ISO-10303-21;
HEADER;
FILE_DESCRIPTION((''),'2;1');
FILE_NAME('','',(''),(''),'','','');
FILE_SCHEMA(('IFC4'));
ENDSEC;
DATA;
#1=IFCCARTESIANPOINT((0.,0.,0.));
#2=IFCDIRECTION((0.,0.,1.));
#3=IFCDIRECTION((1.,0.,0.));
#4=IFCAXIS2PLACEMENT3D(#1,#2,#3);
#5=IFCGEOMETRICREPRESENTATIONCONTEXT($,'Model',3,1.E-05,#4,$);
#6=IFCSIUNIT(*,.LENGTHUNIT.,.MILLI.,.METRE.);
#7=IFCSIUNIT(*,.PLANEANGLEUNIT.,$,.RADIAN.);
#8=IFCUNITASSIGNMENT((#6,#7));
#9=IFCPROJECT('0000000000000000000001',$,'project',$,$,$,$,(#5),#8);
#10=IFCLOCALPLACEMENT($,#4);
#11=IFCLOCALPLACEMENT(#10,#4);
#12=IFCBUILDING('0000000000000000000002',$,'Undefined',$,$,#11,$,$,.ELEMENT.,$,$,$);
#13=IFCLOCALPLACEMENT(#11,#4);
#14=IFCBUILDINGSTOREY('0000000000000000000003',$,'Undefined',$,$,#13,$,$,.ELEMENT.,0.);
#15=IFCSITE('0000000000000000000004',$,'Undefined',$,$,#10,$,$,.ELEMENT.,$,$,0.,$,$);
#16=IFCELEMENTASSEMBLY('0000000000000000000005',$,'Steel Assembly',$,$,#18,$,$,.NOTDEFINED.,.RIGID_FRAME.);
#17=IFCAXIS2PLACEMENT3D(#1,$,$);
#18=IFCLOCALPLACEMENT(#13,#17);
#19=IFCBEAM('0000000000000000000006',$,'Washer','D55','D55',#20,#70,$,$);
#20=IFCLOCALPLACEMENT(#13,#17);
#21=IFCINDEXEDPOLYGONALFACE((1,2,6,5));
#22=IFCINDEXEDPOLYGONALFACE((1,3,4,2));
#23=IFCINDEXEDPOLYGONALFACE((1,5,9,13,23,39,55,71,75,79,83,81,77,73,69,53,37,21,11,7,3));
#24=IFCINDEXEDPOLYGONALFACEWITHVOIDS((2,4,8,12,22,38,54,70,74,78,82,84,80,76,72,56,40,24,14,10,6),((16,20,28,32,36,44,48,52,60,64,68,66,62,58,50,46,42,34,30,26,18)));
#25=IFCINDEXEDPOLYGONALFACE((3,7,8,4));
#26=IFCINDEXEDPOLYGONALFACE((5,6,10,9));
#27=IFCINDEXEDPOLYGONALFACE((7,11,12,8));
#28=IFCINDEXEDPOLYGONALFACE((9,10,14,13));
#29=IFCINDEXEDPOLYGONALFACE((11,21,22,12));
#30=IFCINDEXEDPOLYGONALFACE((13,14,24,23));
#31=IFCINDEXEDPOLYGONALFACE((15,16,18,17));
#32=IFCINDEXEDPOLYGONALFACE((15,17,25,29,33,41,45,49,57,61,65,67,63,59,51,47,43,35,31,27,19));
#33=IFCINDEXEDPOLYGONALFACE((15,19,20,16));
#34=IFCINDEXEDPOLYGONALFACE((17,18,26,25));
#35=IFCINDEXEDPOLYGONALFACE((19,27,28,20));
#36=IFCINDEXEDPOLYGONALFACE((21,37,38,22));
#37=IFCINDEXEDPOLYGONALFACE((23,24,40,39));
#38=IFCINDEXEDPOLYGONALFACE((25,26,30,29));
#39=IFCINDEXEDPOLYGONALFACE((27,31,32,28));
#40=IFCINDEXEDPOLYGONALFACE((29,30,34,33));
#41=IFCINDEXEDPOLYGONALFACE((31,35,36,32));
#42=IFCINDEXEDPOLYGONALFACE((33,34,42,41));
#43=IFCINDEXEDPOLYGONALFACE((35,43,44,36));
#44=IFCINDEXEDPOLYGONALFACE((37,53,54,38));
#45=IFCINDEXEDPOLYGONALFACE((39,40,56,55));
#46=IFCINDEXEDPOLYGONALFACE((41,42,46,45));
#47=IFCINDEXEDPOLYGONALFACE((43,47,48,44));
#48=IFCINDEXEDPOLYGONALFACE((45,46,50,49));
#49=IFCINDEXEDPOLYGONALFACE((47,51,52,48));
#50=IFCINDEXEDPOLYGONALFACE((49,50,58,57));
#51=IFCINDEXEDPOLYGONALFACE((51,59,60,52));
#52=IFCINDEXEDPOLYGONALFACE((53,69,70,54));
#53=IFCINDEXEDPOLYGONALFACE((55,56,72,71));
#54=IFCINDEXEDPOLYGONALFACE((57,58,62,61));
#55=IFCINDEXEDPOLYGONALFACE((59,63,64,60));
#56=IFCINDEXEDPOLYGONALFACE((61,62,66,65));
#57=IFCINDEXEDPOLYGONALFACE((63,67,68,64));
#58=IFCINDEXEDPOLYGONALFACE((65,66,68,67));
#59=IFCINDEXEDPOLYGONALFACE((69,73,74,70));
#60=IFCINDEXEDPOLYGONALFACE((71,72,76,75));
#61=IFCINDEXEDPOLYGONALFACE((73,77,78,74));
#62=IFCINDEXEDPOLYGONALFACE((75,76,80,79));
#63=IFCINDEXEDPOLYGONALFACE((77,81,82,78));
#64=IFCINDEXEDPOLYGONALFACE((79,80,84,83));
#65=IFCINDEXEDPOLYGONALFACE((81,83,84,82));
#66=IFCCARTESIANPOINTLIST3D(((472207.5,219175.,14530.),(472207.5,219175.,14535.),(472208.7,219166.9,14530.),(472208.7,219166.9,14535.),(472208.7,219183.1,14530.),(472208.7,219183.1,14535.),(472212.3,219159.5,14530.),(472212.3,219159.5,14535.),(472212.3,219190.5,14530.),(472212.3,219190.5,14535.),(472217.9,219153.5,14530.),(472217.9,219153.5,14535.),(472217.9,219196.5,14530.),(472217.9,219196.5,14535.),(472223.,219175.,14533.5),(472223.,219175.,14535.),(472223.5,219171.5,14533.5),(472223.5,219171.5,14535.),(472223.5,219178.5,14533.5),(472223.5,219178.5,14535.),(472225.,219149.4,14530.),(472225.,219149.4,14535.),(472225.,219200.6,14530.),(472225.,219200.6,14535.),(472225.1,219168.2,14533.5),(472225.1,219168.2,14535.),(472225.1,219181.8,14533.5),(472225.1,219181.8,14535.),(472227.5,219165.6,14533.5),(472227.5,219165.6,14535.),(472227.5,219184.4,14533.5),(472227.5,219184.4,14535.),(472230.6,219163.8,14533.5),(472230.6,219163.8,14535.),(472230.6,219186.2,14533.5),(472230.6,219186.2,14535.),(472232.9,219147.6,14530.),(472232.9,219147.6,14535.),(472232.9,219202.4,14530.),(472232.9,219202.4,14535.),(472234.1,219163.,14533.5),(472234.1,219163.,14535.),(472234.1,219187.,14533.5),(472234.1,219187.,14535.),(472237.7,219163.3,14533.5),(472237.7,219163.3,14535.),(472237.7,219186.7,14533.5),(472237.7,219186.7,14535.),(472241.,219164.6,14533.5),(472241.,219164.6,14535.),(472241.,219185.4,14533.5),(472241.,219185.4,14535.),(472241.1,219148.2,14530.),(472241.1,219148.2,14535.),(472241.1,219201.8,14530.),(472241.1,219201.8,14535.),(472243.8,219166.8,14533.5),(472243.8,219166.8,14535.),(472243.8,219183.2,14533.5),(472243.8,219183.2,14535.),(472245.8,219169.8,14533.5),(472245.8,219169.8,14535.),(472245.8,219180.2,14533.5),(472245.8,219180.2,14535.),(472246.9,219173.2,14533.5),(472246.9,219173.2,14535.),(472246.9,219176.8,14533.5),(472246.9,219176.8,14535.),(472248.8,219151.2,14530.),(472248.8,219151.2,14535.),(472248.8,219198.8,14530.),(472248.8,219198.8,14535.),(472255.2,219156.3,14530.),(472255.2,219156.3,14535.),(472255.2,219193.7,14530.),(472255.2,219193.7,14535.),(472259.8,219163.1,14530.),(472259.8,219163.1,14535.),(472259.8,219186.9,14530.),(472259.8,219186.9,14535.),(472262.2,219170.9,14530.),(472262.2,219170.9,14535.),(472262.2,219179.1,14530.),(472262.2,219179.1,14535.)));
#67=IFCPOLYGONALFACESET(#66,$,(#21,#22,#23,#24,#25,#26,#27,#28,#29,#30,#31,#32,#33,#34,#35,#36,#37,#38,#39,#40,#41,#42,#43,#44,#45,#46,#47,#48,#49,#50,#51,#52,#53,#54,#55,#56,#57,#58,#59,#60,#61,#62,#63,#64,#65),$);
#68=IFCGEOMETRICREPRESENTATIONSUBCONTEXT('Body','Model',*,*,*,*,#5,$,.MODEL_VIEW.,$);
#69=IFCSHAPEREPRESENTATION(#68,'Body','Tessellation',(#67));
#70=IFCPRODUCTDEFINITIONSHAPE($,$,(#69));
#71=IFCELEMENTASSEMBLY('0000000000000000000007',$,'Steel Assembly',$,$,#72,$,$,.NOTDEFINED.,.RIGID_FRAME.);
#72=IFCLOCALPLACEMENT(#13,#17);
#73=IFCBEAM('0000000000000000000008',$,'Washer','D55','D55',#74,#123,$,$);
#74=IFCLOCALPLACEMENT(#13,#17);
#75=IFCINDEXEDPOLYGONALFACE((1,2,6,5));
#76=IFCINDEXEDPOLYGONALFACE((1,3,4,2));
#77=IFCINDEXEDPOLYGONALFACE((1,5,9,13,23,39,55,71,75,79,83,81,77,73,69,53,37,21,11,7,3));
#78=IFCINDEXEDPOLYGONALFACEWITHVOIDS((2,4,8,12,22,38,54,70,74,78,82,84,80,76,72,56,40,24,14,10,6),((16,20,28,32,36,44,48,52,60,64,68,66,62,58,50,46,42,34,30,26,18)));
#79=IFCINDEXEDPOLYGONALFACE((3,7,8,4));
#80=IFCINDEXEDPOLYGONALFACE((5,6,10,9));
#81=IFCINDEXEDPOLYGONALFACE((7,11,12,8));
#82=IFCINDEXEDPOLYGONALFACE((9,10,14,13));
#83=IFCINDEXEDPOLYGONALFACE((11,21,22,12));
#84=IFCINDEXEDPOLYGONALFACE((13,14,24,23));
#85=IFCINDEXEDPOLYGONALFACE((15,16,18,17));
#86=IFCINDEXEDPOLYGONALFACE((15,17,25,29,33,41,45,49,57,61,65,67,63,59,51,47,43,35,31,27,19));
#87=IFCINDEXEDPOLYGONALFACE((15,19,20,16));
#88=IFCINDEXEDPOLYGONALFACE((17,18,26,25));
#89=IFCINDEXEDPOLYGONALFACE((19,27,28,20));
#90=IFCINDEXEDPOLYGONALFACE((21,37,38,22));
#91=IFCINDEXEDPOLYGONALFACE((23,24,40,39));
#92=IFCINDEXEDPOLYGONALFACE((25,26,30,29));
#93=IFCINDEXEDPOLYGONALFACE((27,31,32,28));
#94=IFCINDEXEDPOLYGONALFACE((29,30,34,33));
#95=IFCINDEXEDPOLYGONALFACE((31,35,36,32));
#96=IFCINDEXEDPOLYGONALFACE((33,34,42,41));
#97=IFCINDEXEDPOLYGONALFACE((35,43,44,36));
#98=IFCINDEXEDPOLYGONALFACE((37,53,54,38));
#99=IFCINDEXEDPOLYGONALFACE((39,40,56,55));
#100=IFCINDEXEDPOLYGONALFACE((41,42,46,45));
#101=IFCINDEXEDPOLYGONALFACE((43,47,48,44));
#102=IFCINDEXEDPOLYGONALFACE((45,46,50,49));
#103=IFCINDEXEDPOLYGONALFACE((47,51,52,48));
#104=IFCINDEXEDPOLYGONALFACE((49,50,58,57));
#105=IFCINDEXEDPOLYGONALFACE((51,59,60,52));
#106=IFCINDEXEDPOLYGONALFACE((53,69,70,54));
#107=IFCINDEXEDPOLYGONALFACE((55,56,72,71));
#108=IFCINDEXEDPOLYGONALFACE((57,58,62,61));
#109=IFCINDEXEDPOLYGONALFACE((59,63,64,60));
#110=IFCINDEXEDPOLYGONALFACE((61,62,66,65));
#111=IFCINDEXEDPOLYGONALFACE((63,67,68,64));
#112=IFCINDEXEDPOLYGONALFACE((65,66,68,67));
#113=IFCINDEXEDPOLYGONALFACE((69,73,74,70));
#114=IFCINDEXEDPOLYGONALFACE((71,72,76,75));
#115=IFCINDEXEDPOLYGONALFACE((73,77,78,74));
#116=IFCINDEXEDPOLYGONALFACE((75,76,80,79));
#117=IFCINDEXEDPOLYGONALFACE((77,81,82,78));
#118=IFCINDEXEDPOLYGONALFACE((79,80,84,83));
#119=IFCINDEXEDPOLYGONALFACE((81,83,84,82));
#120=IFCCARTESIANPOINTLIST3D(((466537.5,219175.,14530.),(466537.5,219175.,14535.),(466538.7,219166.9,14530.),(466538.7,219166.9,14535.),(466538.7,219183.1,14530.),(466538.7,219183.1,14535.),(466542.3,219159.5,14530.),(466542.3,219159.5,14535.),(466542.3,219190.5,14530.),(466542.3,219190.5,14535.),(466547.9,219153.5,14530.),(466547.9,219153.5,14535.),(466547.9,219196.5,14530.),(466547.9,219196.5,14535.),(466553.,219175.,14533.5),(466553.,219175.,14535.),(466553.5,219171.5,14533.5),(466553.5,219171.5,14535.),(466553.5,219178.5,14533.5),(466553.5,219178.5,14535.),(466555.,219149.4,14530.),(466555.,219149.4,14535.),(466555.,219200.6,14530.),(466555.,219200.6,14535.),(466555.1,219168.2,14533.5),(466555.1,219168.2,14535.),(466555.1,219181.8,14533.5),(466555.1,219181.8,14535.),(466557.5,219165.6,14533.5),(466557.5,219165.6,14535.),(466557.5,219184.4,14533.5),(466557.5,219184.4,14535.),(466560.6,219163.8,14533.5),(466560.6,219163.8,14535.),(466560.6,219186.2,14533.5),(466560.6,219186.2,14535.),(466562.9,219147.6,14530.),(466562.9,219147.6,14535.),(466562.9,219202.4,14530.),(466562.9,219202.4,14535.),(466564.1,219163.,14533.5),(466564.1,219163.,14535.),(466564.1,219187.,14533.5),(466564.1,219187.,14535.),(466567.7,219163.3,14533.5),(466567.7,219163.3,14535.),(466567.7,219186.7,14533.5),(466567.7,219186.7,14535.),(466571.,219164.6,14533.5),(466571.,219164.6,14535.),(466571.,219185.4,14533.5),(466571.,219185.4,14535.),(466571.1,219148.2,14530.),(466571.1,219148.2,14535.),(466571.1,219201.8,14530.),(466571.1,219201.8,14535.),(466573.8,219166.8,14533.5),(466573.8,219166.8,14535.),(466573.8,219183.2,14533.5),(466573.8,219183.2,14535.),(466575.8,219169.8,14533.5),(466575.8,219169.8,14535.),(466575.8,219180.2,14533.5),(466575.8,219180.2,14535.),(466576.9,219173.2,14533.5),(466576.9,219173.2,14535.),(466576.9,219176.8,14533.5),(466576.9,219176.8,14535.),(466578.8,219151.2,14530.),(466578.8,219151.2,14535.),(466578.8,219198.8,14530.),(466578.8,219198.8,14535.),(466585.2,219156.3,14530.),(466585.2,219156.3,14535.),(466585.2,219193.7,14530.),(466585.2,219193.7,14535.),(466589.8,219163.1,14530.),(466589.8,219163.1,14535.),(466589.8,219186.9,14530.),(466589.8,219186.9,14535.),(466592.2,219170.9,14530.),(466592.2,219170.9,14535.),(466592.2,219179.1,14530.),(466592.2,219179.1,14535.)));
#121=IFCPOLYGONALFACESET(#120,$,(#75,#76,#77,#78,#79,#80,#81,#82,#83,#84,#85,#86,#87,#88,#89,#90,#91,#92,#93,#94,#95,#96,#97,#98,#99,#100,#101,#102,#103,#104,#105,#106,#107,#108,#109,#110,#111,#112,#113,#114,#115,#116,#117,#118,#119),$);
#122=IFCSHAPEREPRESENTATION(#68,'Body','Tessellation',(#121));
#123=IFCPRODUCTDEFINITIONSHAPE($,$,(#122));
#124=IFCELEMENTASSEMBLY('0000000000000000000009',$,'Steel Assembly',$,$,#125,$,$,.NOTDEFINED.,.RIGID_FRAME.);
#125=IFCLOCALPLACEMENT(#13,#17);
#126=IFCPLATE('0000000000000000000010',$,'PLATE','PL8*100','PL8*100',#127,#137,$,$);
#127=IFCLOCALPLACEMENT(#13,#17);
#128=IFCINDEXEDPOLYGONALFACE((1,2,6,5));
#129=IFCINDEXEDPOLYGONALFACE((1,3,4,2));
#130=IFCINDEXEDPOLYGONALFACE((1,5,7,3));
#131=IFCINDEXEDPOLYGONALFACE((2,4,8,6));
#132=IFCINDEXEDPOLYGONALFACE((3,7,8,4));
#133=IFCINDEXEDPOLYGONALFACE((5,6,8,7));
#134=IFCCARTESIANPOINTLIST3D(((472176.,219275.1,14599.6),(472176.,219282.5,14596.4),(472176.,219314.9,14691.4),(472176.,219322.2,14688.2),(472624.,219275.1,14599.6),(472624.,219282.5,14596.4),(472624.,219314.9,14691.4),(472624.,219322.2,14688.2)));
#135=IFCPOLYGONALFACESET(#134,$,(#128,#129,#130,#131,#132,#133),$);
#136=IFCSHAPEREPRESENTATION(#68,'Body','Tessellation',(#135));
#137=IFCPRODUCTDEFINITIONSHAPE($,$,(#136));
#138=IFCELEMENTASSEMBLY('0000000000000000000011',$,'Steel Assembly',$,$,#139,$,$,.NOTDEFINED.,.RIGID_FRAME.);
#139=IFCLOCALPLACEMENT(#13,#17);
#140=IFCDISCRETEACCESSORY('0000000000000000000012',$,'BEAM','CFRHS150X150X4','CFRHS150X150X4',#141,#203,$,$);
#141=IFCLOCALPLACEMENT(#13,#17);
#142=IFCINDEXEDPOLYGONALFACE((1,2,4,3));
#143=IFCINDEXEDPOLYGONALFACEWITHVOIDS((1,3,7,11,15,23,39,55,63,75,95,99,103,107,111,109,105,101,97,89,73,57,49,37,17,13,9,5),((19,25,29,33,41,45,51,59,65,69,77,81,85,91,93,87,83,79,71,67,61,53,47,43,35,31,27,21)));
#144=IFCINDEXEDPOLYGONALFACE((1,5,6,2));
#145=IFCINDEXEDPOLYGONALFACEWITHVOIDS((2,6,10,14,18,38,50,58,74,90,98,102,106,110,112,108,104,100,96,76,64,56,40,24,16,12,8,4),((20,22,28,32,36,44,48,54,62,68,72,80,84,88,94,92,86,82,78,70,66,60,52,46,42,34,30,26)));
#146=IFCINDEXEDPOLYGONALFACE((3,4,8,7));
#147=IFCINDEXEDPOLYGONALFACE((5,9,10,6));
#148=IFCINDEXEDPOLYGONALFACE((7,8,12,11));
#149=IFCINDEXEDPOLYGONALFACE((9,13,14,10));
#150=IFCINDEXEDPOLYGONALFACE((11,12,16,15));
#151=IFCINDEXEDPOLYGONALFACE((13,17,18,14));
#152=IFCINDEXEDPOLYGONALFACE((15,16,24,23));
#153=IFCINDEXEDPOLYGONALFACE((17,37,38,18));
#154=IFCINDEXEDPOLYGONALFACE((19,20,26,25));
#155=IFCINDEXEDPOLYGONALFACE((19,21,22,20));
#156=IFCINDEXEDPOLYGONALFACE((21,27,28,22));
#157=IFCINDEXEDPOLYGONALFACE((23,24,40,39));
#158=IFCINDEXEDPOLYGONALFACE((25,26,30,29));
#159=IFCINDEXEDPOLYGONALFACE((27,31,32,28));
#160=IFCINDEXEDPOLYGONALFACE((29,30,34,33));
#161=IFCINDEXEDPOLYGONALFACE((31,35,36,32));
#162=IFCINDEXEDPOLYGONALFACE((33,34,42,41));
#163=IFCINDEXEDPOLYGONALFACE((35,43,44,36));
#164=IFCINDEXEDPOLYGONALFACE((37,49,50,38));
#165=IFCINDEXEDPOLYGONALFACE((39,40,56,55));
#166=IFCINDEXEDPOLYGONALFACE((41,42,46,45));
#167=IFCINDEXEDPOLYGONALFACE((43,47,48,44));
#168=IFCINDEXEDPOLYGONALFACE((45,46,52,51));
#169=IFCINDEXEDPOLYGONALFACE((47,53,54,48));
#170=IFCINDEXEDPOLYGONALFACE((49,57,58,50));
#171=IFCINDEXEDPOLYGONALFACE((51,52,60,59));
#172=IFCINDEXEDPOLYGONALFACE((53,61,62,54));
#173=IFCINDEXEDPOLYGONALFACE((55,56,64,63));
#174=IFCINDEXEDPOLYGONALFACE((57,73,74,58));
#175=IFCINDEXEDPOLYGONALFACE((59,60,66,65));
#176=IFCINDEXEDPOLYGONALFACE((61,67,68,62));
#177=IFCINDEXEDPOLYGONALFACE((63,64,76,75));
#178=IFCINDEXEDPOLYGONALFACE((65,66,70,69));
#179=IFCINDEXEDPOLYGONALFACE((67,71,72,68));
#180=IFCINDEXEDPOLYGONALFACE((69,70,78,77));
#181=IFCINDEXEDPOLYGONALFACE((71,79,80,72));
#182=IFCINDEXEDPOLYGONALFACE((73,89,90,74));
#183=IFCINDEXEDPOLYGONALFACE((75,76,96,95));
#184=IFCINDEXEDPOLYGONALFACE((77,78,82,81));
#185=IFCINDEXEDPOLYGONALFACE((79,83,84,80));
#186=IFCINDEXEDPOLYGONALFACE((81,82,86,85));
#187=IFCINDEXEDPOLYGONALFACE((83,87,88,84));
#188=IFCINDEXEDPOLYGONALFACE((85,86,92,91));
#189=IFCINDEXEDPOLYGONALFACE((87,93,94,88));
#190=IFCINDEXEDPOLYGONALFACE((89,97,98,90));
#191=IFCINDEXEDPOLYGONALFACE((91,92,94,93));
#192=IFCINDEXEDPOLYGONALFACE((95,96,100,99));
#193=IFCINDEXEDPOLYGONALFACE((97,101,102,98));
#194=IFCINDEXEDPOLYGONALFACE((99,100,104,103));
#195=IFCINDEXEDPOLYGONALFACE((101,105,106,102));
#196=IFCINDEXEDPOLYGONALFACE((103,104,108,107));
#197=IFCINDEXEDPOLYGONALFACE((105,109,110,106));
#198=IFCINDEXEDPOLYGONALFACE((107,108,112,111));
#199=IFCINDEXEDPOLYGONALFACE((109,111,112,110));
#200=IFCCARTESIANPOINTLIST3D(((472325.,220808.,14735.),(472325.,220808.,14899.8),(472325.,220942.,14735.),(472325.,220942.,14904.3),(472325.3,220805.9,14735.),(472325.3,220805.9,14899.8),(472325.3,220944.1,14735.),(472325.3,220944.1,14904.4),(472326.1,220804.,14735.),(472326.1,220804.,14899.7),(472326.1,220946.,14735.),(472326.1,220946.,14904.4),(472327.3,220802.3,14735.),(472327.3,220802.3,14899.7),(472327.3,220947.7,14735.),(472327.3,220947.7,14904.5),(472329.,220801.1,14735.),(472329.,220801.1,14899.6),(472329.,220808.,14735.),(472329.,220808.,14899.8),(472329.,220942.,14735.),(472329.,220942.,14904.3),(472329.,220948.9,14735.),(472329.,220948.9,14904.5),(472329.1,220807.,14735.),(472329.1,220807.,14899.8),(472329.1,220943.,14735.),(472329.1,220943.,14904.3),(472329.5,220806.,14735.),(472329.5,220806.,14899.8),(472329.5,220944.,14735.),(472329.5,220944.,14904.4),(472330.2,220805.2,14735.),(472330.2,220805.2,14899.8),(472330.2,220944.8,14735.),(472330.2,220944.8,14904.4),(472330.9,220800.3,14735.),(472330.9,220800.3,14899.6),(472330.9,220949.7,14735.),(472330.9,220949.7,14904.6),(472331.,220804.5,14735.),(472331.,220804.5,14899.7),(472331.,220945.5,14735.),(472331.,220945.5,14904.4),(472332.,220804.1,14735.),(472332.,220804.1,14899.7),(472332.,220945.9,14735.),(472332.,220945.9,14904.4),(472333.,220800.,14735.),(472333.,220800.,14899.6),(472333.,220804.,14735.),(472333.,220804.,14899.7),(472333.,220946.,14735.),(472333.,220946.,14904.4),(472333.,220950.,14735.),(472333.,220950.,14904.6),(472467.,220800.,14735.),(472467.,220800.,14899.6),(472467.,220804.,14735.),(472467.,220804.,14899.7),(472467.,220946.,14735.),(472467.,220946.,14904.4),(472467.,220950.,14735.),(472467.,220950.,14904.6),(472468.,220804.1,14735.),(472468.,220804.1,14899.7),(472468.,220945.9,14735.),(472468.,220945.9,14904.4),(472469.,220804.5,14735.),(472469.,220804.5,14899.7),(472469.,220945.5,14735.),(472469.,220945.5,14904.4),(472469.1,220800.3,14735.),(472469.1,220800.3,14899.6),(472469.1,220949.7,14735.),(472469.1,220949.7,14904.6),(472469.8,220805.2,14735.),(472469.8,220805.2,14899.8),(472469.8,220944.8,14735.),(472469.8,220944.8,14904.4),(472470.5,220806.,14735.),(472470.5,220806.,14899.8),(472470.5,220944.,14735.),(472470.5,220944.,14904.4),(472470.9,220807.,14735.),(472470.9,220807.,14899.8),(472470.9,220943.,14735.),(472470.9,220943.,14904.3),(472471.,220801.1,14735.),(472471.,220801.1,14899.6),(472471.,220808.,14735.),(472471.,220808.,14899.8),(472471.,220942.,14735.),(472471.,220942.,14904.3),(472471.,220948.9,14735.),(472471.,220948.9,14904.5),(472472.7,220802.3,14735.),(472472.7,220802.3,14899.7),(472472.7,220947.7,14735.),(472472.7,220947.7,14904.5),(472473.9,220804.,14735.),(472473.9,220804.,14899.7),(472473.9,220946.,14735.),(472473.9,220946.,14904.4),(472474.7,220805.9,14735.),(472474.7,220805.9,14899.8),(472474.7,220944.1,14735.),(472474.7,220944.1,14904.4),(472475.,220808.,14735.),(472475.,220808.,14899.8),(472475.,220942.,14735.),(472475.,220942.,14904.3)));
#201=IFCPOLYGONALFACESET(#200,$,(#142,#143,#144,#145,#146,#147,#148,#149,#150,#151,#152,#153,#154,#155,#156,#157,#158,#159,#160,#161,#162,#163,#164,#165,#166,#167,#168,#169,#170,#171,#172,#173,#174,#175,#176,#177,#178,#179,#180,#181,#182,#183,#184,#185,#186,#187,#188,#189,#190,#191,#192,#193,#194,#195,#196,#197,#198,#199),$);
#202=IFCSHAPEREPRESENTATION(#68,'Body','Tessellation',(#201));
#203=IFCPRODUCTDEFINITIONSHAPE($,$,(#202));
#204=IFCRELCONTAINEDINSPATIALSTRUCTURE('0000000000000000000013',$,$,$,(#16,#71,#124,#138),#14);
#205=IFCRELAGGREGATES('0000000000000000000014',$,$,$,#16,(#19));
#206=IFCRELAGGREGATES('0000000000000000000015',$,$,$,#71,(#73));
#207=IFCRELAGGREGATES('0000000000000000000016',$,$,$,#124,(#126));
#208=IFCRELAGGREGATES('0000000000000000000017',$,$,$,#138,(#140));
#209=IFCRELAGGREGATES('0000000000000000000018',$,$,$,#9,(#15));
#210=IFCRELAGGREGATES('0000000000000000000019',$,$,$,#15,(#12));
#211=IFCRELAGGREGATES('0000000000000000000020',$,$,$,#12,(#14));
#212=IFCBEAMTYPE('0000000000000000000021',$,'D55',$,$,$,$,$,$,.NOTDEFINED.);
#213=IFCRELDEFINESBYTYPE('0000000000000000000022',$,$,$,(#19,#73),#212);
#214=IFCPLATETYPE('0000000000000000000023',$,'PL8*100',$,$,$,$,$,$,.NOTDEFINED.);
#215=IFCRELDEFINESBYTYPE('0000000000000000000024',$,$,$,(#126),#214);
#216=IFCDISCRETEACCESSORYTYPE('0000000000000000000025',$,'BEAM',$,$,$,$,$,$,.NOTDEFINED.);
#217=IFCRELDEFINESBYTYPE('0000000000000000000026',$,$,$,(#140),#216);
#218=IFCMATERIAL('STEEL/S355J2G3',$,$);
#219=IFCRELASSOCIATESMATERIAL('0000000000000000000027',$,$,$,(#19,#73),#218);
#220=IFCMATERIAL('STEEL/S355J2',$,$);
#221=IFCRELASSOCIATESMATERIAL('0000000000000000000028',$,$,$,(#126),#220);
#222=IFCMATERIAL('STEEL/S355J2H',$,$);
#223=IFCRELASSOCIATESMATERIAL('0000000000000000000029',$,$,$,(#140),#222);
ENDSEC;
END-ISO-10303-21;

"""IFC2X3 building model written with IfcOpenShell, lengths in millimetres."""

from ifc_helpers import new_model, si_unit, frame, origin_with_axes, origin_2d_with_axis, place, context, subcontext, project, spatial, polyline, hollow_rectangle, circle, outline, extrude, boolean, clip, halfspace, material, type_object, element, aggregate, save


model = new_model("IFC2X3")

# Units and contexts
model_context = context("Model", 3, precision=1e-05, world=origin_with_axes())
body_context = subcontext(model_context, "Body", "Model", "MODEL_VIEW")
ifc_project = project(units=[si_unit("LENGTHUNIT", "METRE", prefix="MILLI"), si_unit("PLANEANGLEUNIT", "RADIAN")], contexts=[model_context])

# Site, building, storey
site_placement = place(None, origin_with_axes())
site = spatial("IfcSite", under=ifc_project, at=site_placement, Name="Undefined", CompositionType="ELEMENT", RefElevation=0.0)
building_placement = place(site_placement, origin_with_axes())
building = spatial("IfcBuilding", under=site, at=building_placement, Name="Undefined", CompositionType="ELEMENT")
storey_placement = place(building_placement, origin_with_axes())
storey = spatial("IfcBuildingStorey", under=building, at=storey_placement, Name="Undefined", CompositionType="ELEMENT", Elevation=0.0)

# Element assemblies, beams
ifc_material_1 = material(Name="STEEL/S355J2G3")
assembly_1_placement = place(storey_placement, origin_with_axes())
assembly_1 = element("IfcElementAssembly", 1, at=assembly_1_placement, inside=storey, Name="Steel Assembly", AssemblyPlace="NOTDEFINED", PredefinedType="RIGID_FRAME")
beam_type_1 = type_object("IfcBeamType", Name="D55", PredefinedType="NOTDEFINED")
beam_1_placement = place(assembly_1_placement, frame((472235.0, 219175.0, 14535.0), z_axis=(0.0, -1.0, 0.0), x_axis=(0.0, 0.0, -1.0)))
beam_1 = element("IfcBeam", 2, at=beam_1_placement, type_object=beam_type_1, material=ifc_material_1, Name="Washer", Description="D55", ObjectType="D55", context=body_context, shape_type="CSG", body=[
    boolean("DIFFERENCE", extrude(circle(Radius=27.5, at=origin_2d_with_axis()), frame((5.0, 0.0, 0.0), z_axis=(-1.0, 0.0, 0.0), x_axis=(0.0, -1.0, 0.0)), (0.0, 0.0, 1.0), 5.0), extrude(circle(Radius=12.0, at=origin_2d_with_axis()), frame((1.5, 0.0, 0.0), z_axis=(-1.0, 0.0, 0.0), x_axis=(0.0, -1.0, 0.0)), (0.0, 0.0, 1.0), 10.0)),
])
aggregate(assembly_1, [beam_1])
assembly_2_placement = place(storey_placement, origin_with_axes())
assembly_2 = element("IfcElementAssembly", 3, at=assembly_2_placement, inside=storey, Name="Steel Assembly", AssemblyPlace="NOTDEFINED", PredefinedType="RIGID_FRAME")
beam_2_placement = place(assembly_2_placement, frame((466565.0, 219175.0, 14535.0), z_axis=(0.0, -1.0, 0.0), x_axis=(0.0, 0.0, -1.0)))
beam_2 = element("IfcBeam", 4, at=beam_2_placement, type_object=beam_type_1, material=ifc_material_1, Name="Washer", Description="D55", ObjectType="D55", context=body_context, shape_type="CSG", body=[
    boolean("DIFFERENCE", extrude(circle(Radius=27.5, at=origin_2d_with_axis()), frame((5.0, 0.0, 0.0), z_axis=(-1.0, 0.0, 0.0), x_axis=(0.0, -1.0, 0.0)), (0.0, 0.0, 1.0), 5.0), extrude(circle(Radius=12.0, at=origin_2d_with_axis()), frame((1.5, 0.0, 0.0), z_axis=(-1.0, 0.0, 0.0), x_axis=(0.0, -1.0, 0.0)), (0.0, 0.0, 1.0), 10.0)),
])
aggregate(assembly_2, [beam_2])

# Element assembly, plate
assembly_3_placement = place(storey_placement, origin_with_axes())
assembly_3 = element("IfcElementAssembly", 5, at=assembly_3_placement, inside=storey, Name="Steel Assembly", AssemblyPlace="NOTDEFINED", PredefinedType="RIGID_FRAME")
ifc_material_2 = material(Name="STEEL/S355J2")
plate_type = type_object("IfcPlateType", Name="PL8*100", PredefinedType="NOTDEFINED")
plate_placement = place(assembly_3_placement, frame((472176.0, 219278.8, 14598.0), z_axis=(0.0, 0.917713, -0.397244), x_axis=(0.0, 0.397244, 0.917713)))
plate = element("IfcPlate", 6, at=plate_placement, type_object=plate_type, material=ifc_material_2, Name="PLATE", Description="PL8*100", ObjectType="PL8*100", context=body_context, shape_type="SweptSolid", body=[
    extrude(outline(polyline([(0.0, 0.0), (100.0, 0.0), (100.0, 448.0), (0.0, 448.0), (0.0, 0.0)])), frame((0.0, 0.0, -4.0), z_axis=(0.0, 0.0, 1.0), x_axis=(1.0, 0.0, 0.0)), (0.0, 0.0, 1.0), 8.0),
])
aggregate(assembly_3, [plate])

# Element assembly, discrete accessory
assembly_4_placement = place(storey_placement, origin_with_axes())
assembly_4 = element("IfcElementAssembly", 7, at=assembly_4_placement, inside=storey, Name="Steel Assembly", AssemblyPlace="NOTDEFINED", PredefinedType="RIGID_FRAME")
ifc_material_3 = material(Name="STEEL/S355J2H")
discrete_accessory_type_1 = type_object("IfcDiscreteAccessoryType", Name="BEAM")
discrete_accessory_1_placement = place(assembly_4_placement, frame((472400.0, 220875.0, 14720.0), z_axis=(0.0, 0.0, 1.0), x_axis=(1.0, 0.0, 0.0)))
discrete_accessory_1 = element("IfcDiscreteAccessory", 8, at=discrete_accessory_1_placement, type_object=discrete_accessory_type_1, material=ifc_material_3, Name="BEAM", Description="CFRHS150X150X4", ObjectType="CFRHS150X150X4", context=body_context, shape_type="Clipping", body=[
    clip(extrude(hollow_rectangle(XDim=150.0, YDim=150.0, WallThickness=4.0, InnerFilletRadius=4.0, OuterFilletRadius=8.0, at=origin_2d_with_axis()), frame((0.0, 0.0, 184.6), z_axis=(0.0, 0.0, -1.0), x_axis=(0.0, -1.0, 0.0)), (0.0, 0.0, 1.0), 169.6), halfspace(frame((-1000.0, 2.7, 182.2), z_axis=(0.0, 0.033315, -0.999445), x_axis=(0.0, -0.999445, -0.033315)), True)),
])

aggregate(assembly_4, [discrete_accessory_1])

save(model, "model.ifc")
